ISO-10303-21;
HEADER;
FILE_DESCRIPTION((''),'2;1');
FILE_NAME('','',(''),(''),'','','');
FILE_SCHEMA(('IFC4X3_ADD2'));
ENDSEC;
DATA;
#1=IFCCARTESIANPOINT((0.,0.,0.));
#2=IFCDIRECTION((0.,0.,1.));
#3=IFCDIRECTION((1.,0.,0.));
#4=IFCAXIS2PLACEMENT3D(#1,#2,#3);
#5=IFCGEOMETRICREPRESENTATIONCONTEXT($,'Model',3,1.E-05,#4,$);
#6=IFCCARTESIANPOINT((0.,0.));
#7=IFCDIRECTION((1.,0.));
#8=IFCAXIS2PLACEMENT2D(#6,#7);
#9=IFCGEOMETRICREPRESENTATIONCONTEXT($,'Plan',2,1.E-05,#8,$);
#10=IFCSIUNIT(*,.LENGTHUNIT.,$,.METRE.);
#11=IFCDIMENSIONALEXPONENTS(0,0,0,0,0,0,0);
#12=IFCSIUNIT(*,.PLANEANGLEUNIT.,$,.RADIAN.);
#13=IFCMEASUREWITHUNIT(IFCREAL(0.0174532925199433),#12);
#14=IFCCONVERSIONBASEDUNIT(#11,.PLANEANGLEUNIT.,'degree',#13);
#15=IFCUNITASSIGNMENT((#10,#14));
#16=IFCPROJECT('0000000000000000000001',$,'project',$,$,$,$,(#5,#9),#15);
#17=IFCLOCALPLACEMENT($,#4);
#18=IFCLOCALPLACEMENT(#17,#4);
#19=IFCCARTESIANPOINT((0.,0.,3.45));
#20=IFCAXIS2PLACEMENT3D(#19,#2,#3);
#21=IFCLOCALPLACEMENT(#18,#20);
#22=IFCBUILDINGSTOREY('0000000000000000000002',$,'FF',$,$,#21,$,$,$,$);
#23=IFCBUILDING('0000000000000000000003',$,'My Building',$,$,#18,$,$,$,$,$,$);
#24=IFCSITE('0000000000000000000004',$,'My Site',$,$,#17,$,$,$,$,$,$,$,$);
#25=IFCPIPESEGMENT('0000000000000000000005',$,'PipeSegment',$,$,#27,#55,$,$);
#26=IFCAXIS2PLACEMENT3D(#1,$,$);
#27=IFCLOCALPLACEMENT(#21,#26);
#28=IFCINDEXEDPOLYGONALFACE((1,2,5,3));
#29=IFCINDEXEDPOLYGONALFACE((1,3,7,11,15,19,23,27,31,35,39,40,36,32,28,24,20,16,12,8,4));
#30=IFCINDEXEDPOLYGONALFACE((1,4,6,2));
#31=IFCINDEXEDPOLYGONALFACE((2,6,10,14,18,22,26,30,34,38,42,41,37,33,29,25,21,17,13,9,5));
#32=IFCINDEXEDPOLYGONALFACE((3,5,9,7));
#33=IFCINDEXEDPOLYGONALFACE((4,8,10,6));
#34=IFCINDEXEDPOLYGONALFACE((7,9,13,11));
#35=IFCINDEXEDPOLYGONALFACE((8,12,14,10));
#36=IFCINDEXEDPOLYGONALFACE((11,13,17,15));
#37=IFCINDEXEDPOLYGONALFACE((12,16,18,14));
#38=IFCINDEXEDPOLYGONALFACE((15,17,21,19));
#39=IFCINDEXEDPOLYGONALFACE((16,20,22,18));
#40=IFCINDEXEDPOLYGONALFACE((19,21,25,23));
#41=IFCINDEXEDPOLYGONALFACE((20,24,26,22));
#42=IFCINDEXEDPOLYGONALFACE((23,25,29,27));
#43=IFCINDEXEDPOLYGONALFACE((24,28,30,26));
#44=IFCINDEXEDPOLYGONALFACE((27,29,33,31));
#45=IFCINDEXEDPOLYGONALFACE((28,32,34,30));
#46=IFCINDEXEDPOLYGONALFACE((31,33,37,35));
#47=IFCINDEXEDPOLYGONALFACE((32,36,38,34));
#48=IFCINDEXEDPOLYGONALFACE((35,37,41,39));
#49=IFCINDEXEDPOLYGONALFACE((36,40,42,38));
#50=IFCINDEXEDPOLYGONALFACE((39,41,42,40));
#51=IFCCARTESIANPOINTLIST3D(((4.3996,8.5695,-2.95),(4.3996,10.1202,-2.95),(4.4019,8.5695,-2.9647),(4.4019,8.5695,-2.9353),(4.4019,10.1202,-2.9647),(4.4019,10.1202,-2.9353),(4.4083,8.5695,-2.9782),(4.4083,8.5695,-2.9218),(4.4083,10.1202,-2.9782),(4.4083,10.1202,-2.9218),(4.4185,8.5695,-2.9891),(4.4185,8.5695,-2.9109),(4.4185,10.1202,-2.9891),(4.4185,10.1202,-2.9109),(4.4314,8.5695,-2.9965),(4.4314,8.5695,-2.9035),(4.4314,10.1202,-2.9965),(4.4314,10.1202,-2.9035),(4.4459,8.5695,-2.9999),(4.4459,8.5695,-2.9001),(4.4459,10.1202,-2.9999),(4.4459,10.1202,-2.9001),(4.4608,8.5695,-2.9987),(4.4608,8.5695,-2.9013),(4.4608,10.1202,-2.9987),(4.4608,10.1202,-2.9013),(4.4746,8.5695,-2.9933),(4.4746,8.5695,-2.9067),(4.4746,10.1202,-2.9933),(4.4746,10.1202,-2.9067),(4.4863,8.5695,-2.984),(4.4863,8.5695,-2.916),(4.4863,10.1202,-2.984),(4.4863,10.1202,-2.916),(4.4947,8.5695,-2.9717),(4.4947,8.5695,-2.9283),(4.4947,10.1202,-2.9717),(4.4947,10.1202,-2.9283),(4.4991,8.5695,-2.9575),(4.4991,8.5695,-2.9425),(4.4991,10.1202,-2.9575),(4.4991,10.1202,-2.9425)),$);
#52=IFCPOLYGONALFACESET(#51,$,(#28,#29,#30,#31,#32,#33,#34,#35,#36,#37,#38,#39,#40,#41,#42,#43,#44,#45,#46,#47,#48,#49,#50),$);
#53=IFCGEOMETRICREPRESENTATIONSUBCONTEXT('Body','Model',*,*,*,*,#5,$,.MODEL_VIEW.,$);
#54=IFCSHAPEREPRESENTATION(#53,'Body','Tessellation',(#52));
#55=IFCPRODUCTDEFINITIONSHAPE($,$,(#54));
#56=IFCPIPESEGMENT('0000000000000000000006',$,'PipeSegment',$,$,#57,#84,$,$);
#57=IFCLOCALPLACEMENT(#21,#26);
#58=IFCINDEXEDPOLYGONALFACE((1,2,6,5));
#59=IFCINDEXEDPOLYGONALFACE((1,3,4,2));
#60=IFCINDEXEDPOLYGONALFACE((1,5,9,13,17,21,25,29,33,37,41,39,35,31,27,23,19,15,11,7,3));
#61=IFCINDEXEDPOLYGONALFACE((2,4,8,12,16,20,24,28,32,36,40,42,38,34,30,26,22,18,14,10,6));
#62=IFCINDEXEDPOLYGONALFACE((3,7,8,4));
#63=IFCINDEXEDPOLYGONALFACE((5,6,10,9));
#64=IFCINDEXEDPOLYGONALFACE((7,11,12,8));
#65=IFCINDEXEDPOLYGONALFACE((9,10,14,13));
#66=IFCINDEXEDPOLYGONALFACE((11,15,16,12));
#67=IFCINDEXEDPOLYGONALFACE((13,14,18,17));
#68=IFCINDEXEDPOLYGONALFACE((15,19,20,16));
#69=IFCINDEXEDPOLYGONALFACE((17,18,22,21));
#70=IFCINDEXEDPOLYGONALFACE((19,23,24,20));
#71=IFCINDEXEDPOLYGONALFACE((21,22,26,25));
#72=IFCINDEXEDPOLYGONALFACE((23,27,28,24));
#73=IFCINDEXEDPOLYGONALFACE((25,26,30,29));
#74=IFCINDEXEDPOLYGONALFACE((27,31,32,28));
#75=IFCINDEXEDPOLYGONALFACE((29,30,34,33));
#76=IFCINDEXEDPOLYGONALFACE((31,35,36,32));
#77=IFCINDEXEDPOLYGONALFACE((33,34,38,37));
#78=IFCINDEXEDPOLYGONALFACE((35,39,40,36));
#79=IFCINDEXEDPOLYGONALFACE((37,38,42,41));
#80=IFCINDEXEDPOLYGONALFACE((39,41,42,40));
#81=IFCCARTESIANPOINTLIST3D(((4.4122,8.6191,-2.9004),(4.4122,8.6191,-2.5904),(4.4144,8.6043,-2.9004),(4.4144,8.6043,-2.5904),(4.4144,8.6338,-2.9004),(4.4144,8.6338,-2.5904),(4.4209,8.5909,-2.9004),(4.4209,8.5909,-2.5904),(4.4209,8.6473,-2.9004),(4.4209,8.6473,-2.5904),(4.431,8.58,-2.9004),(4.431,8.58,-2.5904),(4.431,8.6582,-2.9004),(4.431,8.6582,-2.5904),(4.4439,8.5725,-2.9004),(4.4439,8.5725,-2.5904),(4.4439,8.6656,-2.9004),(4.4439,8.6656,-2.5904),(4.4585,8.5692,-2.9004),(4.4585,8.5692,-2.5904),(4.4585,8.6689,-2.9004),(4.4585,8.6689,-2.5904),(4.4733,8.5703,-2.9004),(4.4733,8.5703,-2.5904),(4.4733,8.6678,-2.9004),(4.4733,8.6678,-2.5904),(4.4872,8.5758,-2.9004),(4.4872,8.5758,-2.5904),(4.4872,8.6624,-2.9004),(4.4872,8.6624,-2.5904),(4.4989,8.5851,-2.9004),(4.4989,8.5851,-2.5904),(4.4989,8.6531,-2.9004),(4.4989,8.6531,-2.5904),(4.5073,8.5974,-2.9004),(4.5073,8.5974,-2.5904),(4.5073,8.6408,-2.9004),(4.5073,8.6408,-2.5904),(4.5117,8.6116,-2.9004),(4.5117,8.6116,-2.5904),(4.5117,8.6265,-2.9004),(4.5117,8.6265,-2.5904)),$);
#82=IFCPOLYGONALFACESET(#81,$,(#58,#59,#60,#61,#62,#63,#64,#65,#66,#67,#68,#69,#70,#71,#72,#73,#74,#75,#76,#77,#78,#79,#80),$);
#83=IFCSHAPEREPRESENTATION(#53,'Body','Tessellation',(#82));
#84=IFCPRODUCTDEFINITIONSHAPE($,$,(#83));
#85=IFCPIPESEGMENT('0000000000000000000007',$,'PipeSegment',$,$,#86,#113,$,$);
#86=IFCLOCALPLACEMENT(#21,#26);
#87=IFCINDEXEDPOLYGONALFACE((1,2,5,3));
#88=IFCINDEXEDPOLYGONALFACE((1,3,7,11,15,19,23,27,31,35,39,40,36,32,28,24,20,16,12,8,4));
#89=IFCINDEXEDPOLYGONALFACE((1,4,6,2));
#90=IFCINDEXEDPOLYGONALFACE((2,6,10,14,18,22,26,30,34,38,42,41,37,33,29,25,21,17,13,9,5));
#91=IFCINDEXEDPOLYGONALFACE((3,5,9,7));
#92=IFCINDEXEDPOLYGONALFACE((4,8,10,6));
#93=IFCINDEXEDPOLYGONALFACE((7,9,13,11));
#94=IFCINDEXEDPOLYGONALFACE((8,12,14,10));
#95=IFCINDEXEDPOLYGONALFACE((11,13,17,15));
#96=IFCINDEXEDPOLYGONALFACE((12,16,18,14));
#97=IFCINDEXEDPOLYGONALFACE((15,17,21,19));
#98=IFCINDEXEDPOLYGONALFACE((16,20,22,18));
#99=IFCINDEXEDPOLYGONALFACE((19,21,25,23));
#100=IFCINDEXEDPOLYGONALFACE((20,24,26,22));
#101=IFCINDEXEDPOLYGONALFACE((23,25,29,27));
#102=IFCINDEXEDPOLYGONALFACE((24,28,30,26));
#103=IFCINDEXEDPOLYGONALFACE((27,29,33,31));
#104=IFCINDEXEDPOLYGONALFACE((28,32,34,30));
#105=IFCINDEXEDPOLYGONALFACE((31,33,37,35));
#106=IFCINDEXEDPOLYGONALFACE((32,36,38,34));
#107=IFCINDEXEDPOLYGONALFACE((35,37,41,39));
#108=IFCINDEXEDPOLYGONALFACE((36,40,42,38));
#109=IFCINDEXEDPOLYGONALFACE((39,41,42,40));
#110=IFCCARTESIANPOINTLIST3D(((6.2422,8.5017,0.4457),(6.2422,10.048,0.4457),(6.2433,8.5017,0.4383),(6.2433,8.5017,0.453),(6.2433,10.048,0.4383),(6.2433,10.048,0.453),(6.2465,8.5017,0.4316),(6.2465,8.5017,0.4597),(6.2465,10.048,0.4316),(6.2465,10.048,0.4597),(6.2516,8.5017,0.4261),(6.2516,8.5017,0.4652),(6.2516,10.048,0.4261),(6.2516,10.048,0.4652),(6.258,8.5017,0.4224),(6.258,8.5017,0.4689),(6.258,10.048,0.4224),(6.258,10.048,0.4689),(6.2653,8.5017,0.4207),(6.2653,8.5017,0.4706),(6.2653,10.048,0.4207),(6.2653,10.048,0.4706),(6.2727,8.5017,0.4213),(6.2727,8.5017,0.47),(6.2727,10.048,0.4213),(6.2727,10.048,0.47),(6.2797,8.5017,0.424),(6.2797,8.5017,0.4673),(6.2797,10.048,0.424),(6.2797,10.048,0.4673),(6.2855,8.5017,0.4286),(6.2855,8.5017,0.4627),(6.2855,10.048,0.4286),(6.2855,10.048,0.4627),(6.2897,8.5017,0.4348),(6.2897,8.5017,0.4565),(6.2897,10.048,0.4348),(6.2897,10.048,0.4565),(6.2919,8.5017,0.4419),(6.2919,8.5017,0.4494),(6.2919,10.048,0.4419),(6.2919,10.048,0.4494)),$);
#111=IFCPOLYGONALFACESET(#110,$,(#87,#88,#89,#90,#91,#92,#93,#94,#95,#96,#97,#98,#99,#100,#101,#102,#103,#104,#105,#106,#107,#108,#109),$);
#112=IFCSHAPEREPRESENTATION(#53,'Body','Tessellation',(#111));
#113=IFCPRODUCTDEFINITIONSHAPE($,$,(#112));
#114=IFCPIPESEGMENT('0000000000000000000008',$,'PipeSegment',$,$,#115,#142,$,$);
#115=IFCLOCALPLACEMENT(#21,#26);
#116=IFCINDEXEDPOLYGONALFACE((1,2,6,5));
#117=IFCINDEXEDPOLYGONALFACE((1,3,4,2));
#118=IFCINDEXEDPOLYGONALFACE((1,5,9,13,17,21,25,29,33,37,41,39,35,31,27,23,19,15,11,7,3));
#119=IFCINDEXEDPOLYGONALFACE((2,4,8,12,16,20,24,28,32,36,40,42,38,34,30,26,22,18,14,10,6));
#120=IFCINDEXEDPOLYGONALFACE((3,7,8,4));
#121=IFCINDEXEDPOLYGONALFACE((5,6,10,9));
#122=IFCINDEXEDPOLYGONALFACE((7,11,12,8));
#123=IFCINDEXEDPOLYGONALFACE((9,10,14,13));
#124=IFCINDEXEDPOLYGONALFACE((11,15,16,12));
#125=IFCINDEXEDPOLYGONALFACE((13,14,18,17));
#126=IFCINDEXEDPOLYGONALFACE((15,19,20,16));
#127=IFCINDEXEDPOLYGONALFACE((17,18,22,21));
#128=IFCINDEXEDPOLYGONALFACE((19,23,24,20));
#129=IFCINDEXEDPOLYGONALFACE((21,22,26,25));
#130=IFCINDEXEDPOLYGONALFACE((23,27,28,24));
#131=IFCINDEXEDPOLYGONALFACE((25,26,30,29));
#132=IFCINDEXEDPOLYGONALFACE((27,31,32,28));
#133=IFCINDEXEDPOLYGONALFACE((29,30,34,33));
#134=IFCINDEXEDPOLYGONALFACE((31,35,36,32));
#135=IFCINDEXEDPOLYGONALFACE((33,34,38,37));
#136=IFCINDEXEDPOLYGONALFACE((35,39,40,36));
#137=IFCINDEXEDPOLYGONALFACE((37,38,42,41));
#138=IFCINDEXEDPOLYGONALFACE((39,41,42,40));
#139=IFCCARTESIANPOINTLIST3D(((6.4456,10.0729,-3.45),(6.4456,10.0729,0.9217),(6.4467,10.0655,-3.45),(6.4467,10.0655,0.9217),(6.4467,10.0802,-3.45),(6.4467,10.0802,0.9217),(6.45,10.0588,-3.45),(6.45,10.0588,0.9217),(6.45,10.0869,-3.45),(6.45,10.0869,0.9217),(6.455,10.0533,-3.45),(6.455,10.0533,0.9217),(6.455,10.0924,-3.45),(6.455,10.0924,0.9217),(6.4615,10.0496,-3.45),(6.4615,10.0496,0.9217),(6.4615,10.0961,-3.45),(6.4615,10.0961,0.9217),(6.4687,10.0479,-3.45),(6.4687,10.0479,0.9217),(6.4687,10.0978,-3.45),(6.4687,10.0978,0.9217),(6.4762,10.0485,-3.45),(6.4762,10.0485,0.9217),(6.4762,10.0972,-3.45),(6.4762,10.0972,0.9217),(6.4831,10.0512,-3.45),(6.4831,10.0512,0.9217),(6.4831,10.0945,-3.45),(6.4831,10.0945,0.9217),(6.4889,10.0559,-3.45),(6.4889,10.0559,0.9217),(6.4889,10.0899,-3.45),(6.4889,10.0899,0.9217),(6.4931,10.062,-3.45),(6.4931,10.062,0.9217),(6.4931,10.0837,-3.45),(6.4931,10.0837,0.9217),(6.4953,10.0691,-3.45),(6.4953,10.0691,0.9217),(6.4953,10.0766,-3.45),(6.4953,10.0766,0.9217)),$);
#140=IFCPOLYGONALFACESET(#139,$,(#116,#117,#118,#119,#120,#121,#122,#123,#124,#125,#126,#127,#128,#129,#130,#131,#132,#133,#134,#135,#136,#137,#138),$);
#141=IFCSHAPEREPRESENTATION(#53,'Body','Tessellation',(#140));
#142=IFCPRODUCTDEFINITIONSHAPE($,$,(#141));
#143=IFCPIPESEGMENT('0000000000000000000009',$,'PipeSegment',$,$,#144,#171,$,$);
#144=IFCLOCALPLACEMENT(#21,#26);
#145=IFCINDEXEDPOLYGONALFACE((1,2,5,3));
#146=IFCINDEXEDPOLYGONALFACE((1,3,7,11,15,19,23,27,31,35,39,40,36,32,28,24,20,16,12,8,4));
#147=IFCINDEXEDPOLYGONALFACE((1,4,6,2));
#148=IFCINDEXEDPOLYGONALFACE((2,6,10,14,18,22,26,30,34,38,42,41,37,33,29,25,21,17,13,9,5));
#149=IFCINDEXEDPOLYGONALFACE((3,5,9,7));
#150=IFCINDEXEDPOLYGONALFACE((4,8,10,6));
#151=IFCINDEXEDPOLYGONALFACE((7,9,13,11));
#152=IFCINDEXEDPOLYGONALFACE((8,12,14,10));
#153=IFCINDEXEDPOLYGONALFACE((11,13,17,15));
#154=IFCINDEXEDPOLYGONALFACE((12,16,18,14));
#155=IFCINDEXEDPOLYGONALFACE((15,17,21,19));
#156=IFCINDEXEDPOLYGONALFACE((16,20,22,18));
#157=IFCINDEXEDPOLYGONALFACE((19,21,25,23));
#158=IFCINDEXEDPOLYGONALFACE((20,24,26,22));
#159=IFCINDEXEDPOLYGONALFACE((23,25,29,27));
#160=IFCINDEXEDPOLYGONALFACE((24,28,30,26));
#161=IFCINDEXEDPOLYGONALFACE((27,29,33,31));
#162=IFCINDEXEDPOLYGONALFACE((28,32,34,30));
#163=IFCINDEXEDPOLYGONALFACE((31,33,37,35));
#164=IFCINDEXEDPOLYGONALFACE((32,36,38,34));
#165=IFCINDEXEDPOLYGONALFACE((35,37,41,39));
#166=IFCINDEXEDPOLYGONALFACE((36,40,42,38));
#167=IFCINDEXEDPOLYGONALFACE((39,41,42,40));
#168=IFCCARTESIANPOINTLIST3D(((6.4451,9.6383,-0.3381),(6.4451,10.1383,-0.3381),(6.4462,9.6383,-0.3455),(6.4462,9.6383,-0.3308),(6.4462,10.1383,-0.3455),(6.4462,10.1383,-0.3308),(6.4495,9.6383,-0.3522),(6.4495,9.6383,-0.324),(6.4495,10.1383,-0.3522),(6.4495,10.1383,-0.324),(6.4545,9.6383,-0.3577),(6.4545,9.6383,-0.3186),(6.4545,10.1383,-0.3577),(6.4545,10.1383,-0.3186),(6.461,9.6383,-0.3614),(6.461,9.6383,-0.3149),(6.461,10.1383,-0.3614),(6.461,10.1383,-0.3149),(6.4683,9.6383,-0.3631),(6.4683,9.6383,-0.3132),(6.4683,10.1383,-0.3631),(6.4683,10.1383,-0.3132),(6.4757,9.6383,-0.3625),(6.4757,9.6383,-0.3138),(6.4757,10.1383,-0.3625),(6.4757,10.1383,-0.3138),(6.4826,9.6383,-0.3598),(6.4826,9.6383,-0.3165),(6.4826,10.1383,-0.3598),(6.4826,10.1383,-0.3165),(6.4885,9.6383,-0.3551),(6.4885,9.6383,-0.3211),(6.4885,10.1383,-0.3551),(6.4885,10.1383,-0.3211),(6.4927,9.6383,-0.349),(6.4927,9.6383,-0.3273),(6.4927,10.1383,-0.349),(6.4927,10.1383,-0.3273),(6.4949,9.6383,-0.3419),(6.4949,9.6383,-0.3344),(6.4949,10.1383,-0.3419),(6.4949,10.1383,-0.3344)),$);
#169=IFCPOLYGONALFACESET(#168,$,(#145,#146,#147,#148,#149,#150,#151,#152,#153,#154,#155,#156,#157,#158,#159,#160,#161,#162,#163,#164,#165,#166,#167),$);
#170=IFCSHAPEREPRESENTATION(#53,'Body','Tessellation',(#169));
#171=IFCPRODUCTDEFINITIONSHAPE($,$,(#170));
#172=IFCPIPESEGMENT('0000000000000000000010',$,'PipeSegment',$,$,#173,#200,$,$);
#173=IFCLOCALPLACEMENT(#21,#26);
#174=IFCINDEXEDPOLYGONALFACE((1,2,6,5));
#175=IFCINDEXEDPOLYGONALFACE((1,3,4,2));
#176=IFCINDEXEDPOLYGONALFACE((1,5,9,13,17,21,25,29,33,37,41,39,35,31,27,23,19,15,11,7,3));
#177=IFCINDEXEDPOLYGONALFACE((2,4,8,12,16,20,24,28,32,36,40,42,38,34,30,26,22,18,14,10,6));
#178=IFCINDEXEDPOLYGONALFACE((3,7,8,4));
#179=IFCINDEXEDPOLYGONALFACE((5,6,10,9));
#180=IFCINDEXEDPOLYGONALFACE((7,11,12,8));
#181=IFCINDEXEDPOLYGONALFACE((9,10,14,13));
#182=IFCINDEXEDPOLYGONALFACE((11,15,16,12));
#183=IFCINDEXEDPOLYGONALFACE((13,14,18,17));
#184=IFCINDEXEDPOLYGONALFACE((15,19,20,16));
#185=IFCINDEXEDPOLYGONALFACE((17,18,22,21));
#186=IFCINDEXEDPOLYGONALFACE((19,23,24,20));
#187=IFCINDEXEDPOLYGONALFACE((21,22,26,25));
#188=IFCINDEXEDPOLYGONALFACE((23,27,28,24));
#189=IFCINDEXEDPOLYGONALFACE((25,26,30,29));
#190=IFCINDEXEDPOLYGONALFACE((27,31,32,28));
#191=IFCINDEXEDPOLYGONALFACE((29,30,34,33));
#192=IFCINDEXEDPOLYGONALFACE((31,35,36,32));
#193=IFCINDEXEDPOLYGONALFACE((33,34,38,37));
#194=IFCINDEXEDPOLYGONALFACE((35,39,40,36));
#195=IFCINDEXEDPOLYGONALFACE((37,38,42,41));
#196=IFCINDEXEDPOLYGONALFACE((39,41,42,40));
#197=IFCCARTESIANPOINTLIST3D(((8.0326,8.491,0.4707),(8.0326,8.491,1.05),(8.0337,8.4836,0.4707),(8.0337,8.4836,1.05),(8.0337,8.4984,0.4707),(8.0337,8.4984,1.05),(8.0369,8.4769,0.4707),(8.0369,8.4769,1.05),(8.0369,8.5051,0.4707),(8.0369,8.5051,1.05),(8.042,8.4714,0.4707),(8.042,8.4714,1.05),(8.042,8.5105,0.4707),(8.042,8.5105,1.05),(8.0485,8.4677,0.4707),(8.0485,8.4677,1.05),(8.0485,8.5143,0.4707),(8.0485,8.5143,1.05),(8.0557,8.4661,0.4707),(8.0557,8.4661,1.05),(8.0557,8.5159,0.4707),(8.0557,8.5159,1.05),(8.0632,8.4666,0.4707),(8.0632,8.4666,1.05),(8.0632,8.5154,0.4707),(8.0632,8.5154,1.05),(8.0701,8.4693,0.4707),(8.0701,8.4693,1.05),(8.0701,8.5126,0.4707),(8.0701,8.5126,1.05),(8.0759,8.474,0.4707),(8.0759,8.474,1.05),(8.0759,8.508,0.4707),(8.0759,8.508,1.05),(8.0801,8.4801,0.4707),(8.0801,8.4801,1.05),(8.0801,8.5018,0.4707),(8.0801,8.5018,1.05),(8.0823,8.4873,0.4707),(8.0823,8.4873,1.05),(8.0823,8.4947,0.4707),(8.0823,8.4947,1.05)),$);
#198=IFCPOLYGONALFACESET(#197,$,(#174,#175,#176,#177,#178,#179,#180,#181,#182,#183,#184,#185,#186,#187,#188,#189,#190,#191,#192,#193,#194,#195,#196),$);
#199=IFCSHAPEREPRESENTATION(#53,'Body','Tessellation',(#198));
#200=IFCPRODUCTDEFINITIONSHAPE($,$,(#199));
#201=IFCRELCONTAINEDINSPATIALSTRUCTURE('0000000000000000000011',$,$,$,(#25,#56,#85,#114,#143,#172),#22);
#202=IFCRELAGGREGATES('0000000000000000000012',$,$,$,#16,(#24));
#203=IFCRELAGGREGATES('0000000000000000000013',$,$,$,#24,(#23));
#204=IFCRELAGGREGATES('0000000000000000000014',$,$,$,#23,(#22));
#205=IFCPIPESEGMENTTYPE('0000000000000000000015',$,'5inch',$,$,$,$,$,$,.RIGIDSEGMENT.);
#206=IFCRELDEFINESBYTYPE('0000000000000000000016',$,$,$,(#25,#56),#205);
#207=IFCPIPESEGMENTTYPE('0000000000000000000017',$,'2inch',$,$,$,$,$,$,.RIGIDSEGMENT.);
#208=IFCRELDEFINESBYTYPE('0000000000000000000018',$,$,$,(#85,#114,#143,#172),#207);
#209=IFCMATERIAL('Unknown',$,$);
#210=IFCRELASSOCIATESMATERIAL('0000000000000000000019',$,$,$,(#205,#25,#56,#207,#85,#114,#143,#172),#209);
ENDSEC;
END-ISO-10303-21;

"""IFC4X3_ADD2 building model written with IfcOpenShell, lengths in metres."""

from ifc_helpers import new_model, entity, si_unit, converted_unit, frame, origin_with_axes, origin_2d_with_axis, place, context, subcontext, project, spatial, circle, extrude, material, material_profile, profile_set, profile_usage, type_object, element, save


model = new_model("IFC4X3_ADD2")

# Units and contexts
model_context = context("Model", 3, precision=1e-05, world=origin_with_axes())
plan_context = context("Plan", 2, precision=1e-05, world=origin_2d_with_axis())
body_context_1 = subcontext(model_context, "Body", "Model", "MODEL_VIEW")
ifc_project = project(units=[si_unit("LENGTHUNIT", "METRE"), converted_unit("PLANEANGLEUNIT", "degree", entity("IfcReal", 0.0174532925199433), si_unit("PLANEANGLEUNIT", "RADIAN"), dimensions=[0, 0, 0, 0, 0, 0, 0])], contexts=[model_context, plan_context])

# Site, building, storey
site_placement = place(None, origin_with_axes())
site = spatial("IfcSite", under=ifc_project, at=site_placement, Name="My Site")
building_placement = place(site_placement, origin_with_axes())
building = spatial("IfcBuilding", under=site, at=building_placement, Name="My Building")
storey_placement = place(building_placement, frame((0.0, 0.0, 3.45), z_axis=(0.0, 0.0, 1.0), x_axis=(1.0, 0.0, 0.0)))
storey = spatial("IfcBuildingStorey", under=building, at=storey_placement, Name="FF")

# Shared definitions
ifc_material_1 = material(Name="Unknown")

# Pipe segments
ifc_material_profile_1 = material_profile(ifc_material_1, circle(Radius=0.05))
ifc_profile_set_1 = profile_set([ifc_material_profile_1])
pipe_segment_type_1 = type_object("IfcPipeSegmentType", Name="5inch", PredefinedType="RIGIDSEGMENT", material=ifc_profile_set_1)
ifc_profile_usage_1 = profile_usage(ifc_profile_set_1, cardinal=5)
pipe_segment_1_placement = place(storey_placement, frame((4.4496, 8.5695, -2.95), z_axis=(0.0, 1.0, 0.0), x_axis=(-1.0, 0.0, 0.0)))
element("IfcPipeSegment", 1, at=pipe_segment_1_placement, inside=storey, type_object=pipe_segment_type_1, material=ifc_profile_usage_1, Name="PipeSegment", context=body_context_1, shape_type="SweptSolid", body=[
    extrude(circle(Radius=0.05), origin_with_axes(), (0.0, 0.0, 1.0), 1.5508),
])
ifc_profile_usage_2 = profile_usage(ifc_profile_set_1, cardinal=5)
pipe_segment_2_placement = place(storey_placement, frame((4.4622, 8.6191, -2.9004), z_axis=(0.0, 0.0, 1.0), x_axis=(-1.0, 0.0, 0.0)))
element("IfcPipeSegment", 2, at=pipe_segment_2_placement, inside=storey, type_object=pipe_segment_type_1, material=ifc_profile_usage_2, Name="PipeSegment", context=body_context_1, shape_type="SweptSolid", body=[
    extrude(circle(Radius=0.05), origin_with_axes(), (0.0, 0.0, 1.0), 0.3099),
])
ifc_material_profile_2 = material_profile(ifc_material_1, circle(Radius=0.025))
ifc_profile_set_2 = profile_set([ifc_material_profile_2])
ifc_profile_usage_3 = profile_usage(ifc_profile_set_2)
pipe_segment_type_2 = type_object("IfcPipeSegmentType", Name="2inch", PredefinedType="RIGIDSEGMENT", material=ifc_profile_set_2)
pipe_segment_3_placement = place(storey_placement, frame((6.2672, 8.5017, 0.4457), z_axis=(0.0, 1.0, 0.0), x_axis=(-1.0, 0.0, 0.0)))
element("IfcPipeSegment", 3, at=pipe_segment_3_placement, inside=storey, type_object=pipe_segment_type_2, material=ifc_profile_usage_3, Name="PipeSegment", context=body_context_1, shape_type="SweptSolid", body=[
    extrude(circle(Radius=0.025), origin_with_axes(), (0.0, 0.0, 1.0), 1.5464),
])
ifc_profile_usage_4 = profile_usage(ifc_profile_set_2)
pipe_segment_4_placement = place(storey_placement, frame((6.4706, 10.0729, -3.45), z_axis=(0.0, 0.0, 1.0), x_axis=(-1.0, 0.0, 0.0)))
element("IfcPipeSegment", 4, at=pipe_segment_4_placement, inside=storey, type_object=pipe_segment_type_2, material=ifc_profile_usage_4, Name="PipeSegment", context=body_context_1, shape_type="SweptSolid", body=[
    extrude(circle(Radius=0.025), origin_with_axes(), (0.0, 0.0, 1.0), 4.3717),
])
ifc_profile_usage_5 = profile_usage(ifc_profile_set_2)
pipe_segment_5_placement = place(storey_placement, frame((6.4701, 9.6383, -0.3381), z_axis=(0.0, 1.0, 0.0), x_axis=(-1.0, 0.0, 0.0)))
element("IfcPipeSegment", 5, at=pipe_segment_5_placement, inside=storey, type_object=pipe_segment_type_2, material=ifc_profile_usage_5, Name="PipeSegment", context=body_context_1, shape_type="SweptSolid", body=[
    extrude(circle(Radius=0.025), origin_with_axes(), (0.0, 0.0, 1.0), 0.5),
])
ifc_profile_usage_6 = profile_usage(ifc_profile_set_2)
pipe_segment_6_placement = place(storey_placement, frame((8.0576, 8.491, 0.4707), z_axis=(0.0, 0.0, 1.0), x_axis=(-1.0, 0.0, 0.0)))
element("IfcPipeSegment", 6, at=pipe_segment_6_placement, inside=storey, type_object=pipe_segment_type_2, material=ifc_profile_usage_6, Name="PipeSegment", context=body_context_1, shape_type="SweptSolid", body=[
    extrude(circle(Radius=0.025), origin_with_axes(), (0.0, 0.0, 1.0), 0.5793),
])

save(model, "model.ifc")
